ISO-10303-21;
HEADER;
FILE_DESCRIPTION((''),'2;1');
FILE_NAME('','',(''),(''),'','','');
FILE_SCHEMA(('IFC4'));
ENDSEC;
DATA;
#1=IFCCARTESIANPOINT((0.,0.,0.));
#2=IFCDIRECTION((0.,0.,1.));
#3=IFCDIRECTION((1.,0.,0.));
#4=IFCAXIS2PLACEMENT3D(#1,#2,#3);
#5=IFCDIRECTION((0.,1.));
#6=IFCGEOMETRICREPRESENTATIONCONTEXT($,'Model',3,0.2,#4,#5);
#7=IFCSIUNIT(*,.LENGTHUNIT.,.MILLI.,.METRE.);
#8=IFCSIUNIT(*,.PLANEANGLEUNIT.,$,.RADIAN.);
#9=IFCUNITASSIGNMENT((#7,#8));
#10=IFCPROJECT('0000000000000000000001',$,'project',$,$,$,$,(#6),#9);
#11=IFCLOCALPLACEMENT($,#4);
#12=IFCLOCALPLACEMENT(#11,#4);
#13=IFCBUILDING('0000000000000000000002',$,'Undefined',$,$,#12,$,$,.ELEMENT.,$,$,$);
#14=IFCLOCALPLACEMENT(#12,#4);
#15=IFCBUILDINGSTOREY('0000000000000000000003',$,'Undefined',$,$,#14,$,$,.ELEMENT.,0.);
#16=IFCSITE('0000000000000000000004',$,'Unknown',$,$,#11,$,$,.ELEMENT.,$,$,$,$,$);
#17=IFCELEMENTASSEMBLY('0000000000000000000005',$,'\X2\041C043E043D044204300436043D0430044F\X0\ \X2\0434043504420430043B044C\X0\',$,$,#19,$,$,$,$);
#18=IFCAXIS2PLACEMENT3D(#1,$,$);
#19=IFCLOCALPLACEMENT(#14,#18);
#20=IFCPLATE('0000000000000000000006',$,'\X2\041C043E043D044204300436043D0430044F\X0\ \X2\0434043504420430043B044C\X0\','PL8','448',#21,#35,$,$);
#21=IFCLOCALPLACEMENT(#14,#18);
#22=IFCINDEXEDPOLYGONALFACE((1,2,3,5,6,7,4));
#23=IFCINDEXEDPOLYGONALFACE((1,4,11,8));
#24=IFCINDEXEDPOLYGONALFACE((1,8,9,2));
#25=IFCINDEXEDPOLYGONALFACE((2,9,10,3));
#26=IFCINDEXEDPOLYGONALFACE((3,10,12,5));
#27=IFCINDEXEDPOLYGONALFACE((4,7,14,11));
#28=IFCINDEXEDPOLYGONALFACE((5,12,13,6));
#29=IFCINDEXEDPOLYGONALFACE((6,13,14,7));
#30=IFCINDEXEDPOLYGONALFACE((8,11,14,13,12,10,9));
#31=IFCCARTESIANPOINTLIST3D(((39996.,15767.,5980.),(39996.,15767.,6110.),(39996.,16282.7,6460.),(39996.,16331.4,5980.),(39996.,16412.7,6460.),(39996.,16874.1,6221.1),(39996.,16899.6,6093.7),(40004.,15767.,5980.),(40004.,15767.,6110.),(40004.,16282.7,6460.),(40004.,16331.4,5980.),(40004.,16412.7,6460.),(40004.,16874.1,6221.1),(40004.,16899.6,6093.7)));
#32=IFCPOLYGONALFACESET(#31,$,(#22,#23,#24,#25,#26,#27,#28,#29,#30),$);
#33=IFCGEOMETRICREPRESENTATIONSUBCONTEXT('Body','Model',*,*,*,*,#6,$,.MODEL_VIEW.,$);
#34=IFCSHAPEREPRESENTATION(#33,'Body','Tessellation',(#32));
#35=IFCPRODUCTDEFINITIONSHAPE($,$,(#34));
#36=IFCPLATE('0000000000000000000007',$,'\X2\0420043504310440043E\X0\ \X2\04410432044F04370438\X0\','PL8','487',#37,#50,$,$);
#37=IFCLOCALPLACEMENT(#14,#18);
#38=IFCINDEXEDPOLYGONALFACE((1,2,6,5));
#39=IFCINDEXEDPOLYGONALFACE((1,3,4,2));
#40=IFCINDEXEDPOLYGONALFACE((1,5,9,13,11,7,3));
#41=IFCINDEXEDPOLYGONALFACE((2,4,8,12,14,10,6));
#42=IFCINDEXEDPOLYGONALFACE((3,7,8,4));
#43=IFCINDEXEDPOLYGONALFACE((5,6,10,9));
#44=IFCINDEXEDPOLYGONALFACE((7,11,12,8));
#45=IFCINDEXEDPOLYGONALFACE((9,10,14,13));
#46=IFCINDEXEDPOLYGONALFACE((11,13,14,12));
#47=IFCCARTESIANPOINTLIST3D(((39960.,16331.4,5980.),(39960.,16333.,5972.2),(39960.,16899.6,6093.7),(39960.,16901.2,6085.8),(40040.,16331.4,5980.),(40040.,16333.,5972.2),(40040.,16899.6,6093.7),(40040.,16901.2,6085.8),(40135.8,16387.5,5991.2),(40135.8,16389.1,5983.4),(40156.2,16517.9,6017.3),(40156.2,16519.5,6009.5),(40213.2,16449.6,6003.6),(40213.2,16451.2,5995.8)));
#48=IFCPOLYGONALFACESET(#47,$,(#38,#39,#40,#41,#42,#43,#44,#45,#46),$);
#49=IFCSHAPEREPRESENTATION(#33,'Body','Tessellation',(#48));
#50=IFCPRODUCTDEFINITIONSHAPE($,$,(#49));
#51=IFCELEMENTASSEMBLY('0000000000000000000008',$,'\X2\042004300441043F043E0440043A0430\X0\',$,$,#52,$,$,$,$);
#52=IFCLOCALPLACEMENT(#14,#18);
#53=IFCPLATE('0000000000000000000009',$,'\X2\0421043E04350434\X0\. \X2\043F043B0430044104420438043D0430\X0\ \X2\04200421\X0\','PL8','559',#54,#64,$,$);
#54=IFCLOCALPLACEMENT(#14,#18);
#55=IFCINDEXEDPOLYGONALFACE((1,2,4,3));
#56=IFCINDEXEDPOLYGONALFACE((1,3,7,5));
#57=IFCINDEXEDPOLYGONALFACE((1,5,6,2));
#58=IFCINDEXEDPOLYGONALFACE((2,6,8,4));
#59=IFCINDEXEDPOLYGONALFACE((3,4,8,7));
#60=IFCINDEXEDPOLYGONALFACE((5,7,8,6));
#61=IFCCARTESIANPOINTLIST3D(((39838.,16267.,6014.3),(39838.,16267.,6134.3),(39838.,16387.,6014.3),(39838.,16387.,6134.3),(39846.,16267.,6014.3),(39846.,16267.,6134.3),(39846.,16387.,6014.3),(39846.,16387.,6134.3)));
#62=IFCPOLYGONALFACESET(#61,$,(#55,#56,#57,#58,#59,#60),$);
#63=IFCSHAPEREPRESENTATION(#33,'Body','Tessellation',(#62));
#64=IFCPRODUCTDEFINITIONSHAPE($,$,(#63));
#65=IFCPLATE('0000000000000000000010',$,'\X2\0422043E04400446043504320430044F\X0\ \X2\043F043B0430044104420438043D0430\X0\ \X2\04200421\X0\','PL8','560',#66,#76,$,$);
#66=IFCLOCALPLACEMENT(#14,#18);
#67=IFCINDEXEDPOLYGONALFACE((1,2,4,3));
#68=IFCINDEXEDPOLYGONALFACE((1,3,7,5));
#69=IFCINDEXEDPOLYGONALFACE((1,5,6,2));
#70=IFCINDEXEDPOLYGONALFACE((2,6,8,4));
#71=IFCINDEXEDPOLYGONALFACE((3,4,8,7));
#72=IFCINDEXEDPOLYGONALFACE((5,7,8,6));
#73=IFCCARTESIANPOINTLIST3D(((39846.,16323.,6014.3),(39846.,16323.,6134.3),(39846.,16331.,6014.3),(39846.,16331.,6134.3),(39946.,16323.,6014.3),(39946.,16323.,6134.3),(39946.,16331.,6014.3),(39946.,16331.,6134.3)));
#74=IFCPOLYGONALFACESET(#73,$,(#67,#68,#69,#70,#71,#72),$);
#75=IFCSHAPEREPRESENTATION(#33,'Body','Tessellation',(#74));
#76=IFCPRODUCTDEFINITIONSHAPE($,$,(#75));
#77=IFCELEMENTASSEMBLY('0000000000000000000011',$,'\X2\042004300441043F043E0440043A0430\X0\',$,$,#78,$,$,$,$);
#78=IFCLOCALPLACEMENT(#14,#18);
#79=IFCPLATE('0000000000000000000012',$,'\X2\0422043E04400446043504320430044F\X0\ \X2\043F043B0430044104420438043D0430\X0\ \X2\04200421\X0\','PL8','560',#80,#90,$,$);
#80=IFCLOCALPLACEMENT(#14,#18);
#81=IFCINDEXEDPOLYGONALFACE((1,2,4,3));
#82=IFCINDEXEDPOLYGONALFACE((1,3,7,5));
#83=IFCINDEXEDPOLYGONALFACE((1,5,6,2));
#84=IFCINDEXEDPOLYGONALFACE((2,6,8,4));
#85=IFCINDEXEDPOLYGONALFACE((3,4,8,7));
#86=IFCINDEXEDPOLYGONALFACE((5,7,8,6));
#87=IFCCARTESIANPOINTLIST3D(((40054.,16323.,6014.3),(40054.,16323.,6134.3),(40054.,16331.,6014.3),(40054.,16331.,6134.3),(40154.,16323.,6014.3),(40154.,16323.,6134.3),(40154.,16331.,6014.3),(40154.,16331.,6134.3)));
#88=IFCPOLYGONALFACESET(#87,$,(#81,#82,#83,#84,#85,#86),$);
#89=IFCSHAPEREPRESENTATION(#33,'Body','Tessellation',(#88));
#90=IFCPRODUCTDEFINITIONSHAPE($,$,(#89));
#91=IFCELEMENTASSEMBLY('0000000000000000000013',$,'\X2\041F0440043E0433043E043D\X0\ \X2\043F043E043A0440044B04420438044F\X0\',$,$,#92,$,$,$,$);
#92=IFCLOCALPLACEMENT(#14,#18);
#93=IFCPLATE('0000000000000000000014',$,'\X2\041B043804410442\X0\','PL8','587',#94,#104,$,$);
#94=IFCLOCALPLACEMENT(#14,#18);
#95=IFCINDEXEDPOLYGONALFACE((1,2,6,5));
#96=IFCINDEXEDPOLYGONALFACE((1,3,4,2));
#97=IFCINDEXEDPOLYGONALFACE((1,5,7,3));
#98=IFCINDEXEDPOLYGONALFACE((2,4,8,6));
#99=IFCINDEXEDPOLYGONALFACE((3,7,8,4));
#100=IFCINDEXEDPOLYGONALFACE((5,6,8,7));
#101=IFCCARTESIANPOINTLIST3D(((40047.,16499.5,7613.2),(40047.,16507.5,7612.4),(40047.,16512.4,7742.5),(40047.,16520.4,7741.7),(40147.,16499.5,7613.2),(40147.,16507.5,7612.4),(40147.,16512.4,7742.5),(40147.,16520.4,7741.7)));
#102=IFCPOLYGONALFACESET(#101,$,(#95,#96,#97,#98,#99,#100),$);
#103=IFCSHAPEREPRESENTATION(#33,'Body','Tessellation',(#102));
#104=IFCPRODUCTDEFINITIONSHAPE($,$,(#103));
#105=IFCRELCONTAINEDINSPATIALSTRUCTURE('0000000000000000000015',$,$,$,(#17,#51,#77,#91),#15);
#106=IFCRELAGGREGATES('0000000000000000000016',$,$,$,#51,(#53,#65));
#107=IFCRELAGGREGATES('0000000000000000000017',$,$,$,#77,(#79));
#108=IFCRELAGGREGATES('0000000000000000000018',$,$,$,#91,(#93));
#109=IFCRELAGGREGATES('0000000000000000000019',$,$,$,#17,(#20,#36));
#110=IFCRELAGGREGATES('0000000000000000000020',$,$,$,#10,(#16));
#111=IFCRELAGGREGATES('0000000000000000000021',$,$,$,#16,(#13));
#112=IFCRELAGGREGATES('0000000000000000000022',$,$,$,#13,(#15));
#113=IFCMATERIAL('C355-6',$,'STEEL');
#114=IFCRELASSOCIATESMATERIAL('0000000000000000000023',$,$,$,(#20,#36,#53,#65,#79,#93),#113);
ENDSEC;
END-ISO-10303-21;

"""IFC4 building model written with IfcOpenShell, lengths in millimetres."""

from ifc_helpers import new_model, si_unit, direction, frame, origin_with_axes, place, context, subcontext, project, spatial, line, indexed_curve, outline, extrude, material, element, aggregate, save


model = new_model("IFC4")

# Units and contexts
model_context = context("Model", 3, precision=0.2, world=origin_with_axes(), true_north=direction((0.0, 1.0)))
body_context = subcontext(model_context, "Body", "Model", "MODEL_VIEW")
ifc_project = project(units=[si_unit("LENGTHUNIT", "METRE", prefix="MILLI"), si_unit("PLANEANGLEUNIT", "RADIAN")], contexts=[model_context])

# Site, building, storey
site_placement = place(None, origin_with_axes())
site = spatial("IfcSite", under=ifc_project, at=site_placement, Name="Unknown", CompositionType="ELEMENT")
building_placement = place(site_placement, origin_with_axes())
building = spatial("IfcBuilding", under=site, at=building_placement, Name="Undefined", CompositionType="ELEMENT")
storey_placement = place(building_placement, origin_with_axes())
storey = spatial("IfcBuildingStorey", under=building, at=storey_placement, Name="Undefined", CompositionType="ELEMENT", Elevation=0.0)

# Element assemblies, plates
ifc_material_1 = material(Name="C355-6", Category="STEEL")
assembly_1_placement = place(storey_placement, frame((40000.0, 16331.4, 5980.0), z_axis=(-1.0, 0.0, 0.0), x_axis=(0.0, -1.0, 0.0)))
assembly_1 = element("IfcElementAssembly", 1, at=assembly_1_placement, inside=storey, Name="Монтажная деталь")
plate_1_placement = place(assembly_1_placement, origin_with_axes())
plate_1 = element("IfcPlate", 2, at=plate_1_placement, material=ifc_material_1, Name="Монтажная деталь", Description="PL8", ObjectType="448", context=body_context, shape_type="SolidModel", body=[
    extrude(outline(indexed_curve([(0.0, 0.0), (564.4, 0.0), (564.4, 130.0), (48.7, 480.0), (-81.3, 480.0), (-542.8, 241.1), (-568.3, 113.7)], segments=[line(1, 2, 3, 4, 5, 6, 7, 1)])), frame((0.0, 0.0, 4.0), z_axis=(0.0, 0.0, 1.0), x_axis=(1.0, 0.0, 0.0)), (0.0, 0.0, -1.0), 8.0),
])
plate_2_placement = place(assembly_1_placement, frame((-0.8, -3.9, 40.0), z_axis=(0.196116, 0.980581, 0.0), x_axis=(0.0, 0.0, -1.0)))
plate_2 = element("IfcPlate", 3, at=plate_2_placement, material=ifc_material_1, Name="Ребро связи", Description="PL8", ObjectType="487", context=body_context, shape_type="SolidModel", body=[
    extrude(outline(indexed_curve([(0.0, 0.0), (80.0, 0.0), (175.8, 57.3), (253.2, 120.5), (196.2, 190.2), (80.0, 579.5), (0.0, 579.5)], segments=[line(1, 2, 3, 4, 5, 6, 7, 1)])), frame((0.0, 0.0, 4.0), z_axis=(0.0, 0.0, 1.0), x_axis=(1.0, 0.0, 0.0)), (0.0, 0.0, -1.0), 8.0),
])
assembly_2_placement = place(storey_placement, frame((34000.0, 16327.0, 6074.3), z_axis=(0.0, -1.0, 0.0), x_axis=(1.0, 0.0, 0.0)))
assembly_2 = element("IfcElementAssembly", 4, at=assembly_2_placement, inside=storey, Name="Распорка")
plate_3_placement = place(assembly_2_placement, frame((5842.0, -60.0, 60.0), z_axis=(1.0, 0.0, 0.0), x_axis=(0.0, 0.0, -1.0)))
plate_3 = element("IfcPlate", 5, at=plate_3_placement, material=ifc_material_1, Name="Соед. пластина РС", Description="PL8", ObjectType="559", context=body_context, shape_type="SolidModel", body=[
    extrude(outline(indexed_curve([(0.0, 0.0), (120.0, 0.0), (120.0, 120.0), (0.0, 120.0)], segments=[line(1, 2, 3, 4, 1)])), frame((0.0, 0.0, 4.0), z_axis=(0.0, 0.0, 1.0), x_axis=(1.0, 0.0, 0.0)), (0.0, 0.0, -1.0), 8.0),
])
plate_4_placement = place(assembly_2_placement, frame((5946.0, -60.0, 0.0), z_axis=(0.0, 0.0, 1.0), x_axis=(0.0, 1.0, 0.0)))
plate_4 = element("IfcPlate", 6, at=plate_4_placement, material=ifc_material_1, Name="Торцевая пластина РС", Description="PL8", ObjectType="560", context=body_context, shape_type="SolidModel", body=[
    extrude(outline(indexed_curve([(0.0, 0.0), (120.0, 0.0), (120.0, 100.0), (0.0, 100.0)], segments=[line(1, 2, 3, 4, 1)])), frame((0.0, 0.0, 4.0), z_axis=(0.0, 0.0, 1.0), x_axis=(1.0, 0.0, 0.0)), (0.0, 0.0, -1.0), 8.0),
])
aggregate(assembly_2, [plate_3, plate_4])
assembly_3_placement = place(storey_placement, frame((40000.0, 16327.0, 6074.3), z_axis=(0.0, -1.0, 0.0), x_axis=(1.0, 0.0, 0.0)))
assembly_3 = element("IfcElementAssembly", 7, at=assembly_3_placement, inside=storey, Name="Распорка")
plate_5_placement = place(assembly_3_placement, frame((54.0, 60.0, 0.0), z_axis=(0.0, 0.0, 1.0), x_axis=(0.0, -1.0, 0.0)))
plate_5 = element("IfcPlate", 8, at=plate_5_placement, material=ifc_material_1, Name="Торцевая пластина РС", Description="PL8", ObjectType="560", context=body_context, shape_type="SolidModel", body=[
    extrude(outline(indexed_curve([(0.0, 0.0), (120.0, 0.0), (120.0, 100.0), (0.0, 100.0)], segments=[line(1, 2, 3, 4, 1)])), frame((0.0, 0.0, 4.0), z_axis=(0.0, 0.0, 1.0), x_axis=(1.0, 0.0, 0.0)), (0.0, 0.0, -1.0), 8.0),
])
aggregate(assembly_3, [plate_5])

# Element assembly, plate
assembly_4_placement = place(storey_placement, frame((46000.0, 16510.0, 7677.5), z_axis=(0.0, -0.995037, 0.099504), x_axis=(-1.0, 0.0, 0.0)))
assembly_4 = element("IfcElementAssembly", 9, at=assembly_4_placement, inside=storey, Name="Прогон покрытия")
plate_6_placement = place(assembly_4_placement, frame((5953.0, 65.0, 0.0), z_axis=(0.0, 0.0, 1.0), x_axis=(-1.0, 0.0, 0.0)))
plate_6 = element("IfcPlate", 10, at=plate_6_placement, material=ifc_material_1, Name="Лист", Description="PL8", ObjectType="587", context=body_context, shape_type="SolidModel", body=[
    extrude(outline(indexed_curve([(0.0, 0.0), (100.0, 0.0), (100.0, 130.0), (0.0, 130.0)], segments=[line(1, 2, 3, 4, 1)])), frame((0.0, 0.0, 4.0), z_axis=(0.0, 0.0, 1.0), x_axis=(1.0, 0.0, 0.0)), (0.0, 0.0, -1.0), 8.0),
])
aggregate(assembly_4, [plate_6])

aggregate(assembly_1, [plate_1, plate_2])

save(model, "model.ifc")
